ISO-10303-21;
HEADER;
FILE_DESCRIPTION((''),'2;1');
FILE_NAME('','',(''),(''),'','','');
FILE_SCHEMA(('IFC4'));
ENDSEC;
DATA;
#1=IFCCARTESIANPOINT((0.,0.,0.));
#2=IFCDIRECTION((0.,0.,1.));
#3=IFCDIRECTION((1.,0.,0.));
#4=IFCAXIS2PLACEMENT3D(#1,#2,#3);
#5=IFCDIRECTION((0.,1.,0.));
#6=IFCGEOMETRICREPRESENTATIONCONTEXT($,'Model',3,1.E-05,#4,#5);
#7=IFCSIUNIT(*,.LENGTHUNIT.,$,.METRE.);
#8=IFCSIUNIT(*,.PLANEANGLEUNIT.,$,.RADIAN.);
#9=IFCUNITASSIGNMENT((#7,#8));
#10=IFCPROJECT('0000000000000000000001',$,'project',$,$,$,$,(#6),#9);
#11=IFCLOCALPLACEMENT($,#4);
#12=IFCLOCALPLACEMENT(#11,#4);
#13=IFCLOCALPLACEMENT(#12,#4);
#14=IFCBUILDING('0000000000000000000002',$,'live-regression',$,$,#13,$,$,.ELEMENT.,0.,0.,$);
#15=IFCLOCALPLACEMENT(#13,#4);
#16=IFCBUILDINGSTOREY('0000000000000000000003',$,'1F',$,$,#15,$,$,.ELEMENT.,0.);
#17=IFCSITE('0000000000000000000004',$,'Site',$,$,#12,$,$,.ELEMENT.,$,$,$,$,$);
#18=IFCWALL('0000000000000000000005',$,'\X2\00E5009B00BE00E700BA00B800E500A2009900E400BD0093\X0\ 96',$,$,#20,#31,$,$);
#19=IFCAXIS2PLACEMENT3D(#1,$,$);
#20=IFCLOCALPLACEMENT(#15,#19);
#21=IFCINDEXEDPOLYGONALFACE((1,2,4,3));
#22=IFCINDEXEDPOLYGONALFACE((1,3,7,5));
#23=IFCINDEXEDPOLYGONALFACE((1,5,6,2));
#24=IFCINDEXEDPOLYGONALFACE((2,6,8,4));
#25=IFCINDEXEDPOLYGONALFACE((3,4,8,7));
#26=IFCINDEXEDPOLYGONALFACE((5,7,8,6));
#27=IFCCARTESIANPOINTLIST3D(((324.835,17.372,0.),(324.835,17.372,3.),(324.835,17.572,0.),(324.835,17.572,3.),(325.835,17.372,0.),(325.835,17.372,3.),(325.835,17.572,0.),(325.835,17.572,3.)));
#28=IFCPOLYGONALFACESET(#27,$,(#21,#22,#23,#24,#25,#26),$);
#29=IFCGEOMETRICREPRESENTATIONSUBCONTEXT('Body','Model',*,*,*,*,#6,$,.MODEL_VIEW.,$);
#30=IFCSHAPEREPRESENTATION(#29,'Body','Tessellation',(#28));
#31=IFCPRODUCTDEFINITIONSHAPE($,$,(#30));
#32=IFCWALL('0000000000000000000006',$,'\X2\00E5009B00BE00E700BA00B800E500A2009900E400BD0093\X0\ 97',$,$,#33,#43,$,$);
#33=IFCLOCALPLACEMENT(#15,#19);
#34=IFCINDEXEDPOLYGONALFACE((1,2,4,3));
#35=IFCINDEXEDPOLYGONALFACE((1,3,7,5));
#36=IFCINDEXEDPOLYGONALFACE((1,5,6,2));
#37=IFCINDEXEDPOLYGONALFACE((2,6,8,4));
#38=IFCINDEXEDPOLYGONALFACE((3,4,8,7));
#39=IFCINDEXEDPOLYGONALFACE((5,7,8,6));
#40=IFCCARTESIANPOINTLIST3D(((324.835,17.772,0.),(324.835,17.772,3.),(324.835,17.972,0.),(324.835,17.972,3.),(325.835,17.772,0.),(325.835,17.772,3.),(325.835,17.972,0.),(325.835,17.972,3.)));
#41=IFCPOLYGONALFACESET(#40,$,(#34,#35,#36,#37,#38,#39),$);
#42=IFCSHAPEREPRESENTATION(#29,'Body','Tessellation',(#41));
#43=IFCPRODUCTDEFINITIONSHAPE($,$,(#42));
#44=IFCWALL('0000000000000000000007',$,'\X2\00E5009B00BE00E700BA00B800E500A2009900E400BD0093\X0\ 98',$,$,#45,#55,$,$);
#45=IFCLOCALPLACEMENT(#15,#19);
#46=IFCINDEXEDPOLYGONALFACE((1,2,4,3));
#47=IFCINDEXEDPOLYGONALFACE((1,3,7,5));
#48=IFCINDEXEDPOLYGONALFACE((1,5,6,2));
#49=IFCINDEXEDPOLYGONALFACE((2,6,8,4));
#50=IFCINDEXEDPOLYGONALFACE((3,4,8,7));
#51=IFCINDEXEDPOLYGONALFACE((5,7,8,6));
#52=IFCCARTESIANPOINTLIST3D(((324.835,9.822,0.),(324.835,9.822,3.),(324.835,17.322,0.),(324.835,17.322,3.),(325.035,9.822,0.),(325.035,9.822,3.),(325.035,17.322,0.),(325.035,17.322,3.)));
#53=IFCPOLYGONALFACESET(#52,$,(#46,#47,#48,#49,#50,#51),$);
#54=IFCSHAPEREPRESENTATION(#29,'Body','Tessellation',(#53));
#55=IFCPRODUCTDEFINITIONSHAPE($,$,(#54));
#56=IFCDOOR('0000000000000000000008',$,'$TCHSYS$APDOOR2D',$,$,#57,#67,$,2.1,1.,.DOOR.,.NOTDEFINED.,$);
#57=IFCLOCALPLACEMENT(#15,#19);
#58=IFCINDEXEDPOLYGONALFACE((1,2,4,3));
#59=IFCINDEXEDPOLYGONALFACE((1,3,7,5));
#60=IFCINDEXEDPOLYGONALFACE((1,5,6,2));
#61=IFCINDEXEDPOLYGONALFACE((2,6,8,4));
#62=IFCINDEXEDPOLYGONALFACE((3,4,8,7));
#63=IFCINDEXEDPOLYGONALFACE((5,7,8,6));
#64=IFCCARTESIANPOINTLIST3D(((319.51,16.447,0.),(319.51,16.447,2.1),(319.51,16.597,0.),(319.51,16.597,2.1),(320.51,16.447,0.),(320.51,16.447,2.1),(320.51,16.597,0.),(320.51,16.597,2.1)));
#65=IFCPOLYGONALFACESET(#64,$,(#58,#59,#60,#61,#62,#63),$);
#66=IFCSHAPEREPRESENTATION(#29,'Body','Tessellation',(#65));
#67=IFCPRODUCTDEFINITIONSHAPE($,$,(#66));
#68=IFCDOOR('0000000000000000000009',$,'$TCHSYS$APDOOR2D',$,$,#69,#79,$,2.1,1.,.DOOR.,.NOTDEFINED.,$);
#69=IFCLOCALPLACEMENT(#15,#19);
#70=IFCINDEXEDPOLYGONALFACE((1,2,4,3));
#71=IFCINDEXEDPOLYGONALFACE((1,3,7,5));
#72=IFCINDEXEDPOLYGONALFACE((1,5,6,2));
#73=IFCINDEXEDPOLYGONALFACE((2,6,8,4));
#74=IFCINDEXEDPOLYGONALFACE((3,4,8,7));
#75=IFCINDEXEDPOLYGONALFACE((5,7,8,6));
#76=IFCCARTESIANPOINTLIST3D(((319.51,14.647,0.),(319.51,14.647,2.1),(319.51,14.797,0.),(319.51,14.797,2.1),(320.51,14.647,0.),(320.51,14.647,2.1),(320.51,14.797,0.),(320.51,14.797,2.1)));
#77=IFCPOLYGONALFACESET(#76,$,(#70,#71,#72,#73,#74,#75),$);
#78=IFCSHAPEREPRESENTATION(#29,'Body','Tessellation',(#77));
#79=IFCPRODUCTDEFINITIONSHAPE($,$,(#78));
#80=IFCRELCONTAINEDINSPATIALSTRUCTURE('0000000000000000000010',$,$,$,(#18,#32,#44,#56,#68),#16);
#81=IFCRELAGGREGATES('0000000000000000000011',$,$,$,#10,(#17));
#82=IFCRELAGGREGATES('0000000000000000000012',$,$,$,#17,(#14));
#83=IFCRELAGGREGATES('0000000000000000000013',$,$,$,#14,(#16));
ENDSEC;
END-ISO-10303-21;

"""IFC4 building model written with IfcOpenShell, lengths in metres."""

from ifc_helpers import new_model, si_unit, direction, frame, frame_2d, origin_with_axes, place, context, subcontext, project, spatial, rectangle, extrude, element, save


model = new_model("IFC4")

# Units and contexts
model_context = context("Model", 3, precision=1e-05, world=origin_with_axes(), true_north=direction((0.0, 1.0, 0.0)))
body_context = subcontext(model_context, "Body", "Model", "MODEL_VIEW")
ifc_project = project(units=[si_unit("LENGTHUNIT", "METRE"), si_unit("PLANEANGLEUNIT", "RADIAN")], contexts=[model_context])

# Site, building, storey
placement = place(None, origin_with_axes())
site_placement = place(placement, origin_with_axes())
site = spatial("IfcSite", under=ifc_project, at=site_placement, Name="Site", CompositionType="ELEMENT")
building_placement = place(site_placement, origin_with_axes())
building = spatial("IfcBuilding", under=site, at=building_placement, Name="live-regression", CompositionType="ELEMENT", ElevationOfRefHeight=0.0, ElevationOfTerrain=0.0)
storey_placement = place(building_placement, origin_with_axes())
storey = spatial("IfcBuildingStorey", under=building, at=storey_placement, Name="1F", CompositionType="ELEMENT", Elevation=0.0)

# Walls
for number, where, z_axis, x_axis, name in (
    (1, (325.335, 17.472, 0.0), (0.0, 0.0, 1.0), (1.0, 0.0, 0.0), "å\u009b¾çº¸å¢\u0099ä½\u0093 96"),
    (2, (325.335, 17.872, 0.0), (0.0, 0.0, 1.0), (1.0, 0.0, 0.0), "å\u009b¾çº¸å¢\u0099ä½\u0093 97"),
):
    element("IfcWall", number, at=place(storey_placement, frame(where, z_axis=z_axis, x_axis=x_axis)), inside=storey, Name=name, context=body_context, shape_type="SweptSolid", body=[
        extrude(rectangle(XDim=1.0, YDim=0.2, at=frame_2d((0.0, 0.0), x_axis=(1.0, 0.0, 0.0))), frame((0.0, 0.0, 0.0), z_axis=(0.0, 0.0, 1.0)), (0.0, 0.0, 1.0), 3.0),
    ])
wall_1_placement = place(storey_placement, frame((324.935, 13.572, 0.0), z_axis=(0.0, 0.0, 1.0), x_axis=(0.0, 1.0, 0.0)))
element("IfcWall", 3, at=wall_1_placement, inside=storey, Name="å\u009b¾çº¸å¢\u0099ä½\u0093 98", context=body_context, shape_type="SweptSolid", body=[
    extrude(rectangle(XDim=7.5, YDim=0.2, at=frame_2d((0.0, 0.0), x_axis=(1.0, 0.0, 0.0))), frame((0.0, 0.0, 0.0), z_axis=(0.0, 0.0, 1.0)), (0.0, 0.0, 1.0), 3.0),
])

# Doors
for number, where, z_axis, x_axis, name in (
    (4, (320.01, 16.522, 0.0), (0.0, 0.0, 1.0), (1.0, 0.0, 0.0), "$TCHSYS$APDOOR2D"),
    (5, (320.01, 14.722, 0.0), (0.0, 0.0, 1.0), (1.0, 0.0, 0.0), "$TCHSYS$APDOOR2D"),
):
    element("IfcDoor", number, at=place(storey_placement, frame(where, z_axis=z_axis, x_axis=x_axis)), inside=storey, Name=name, OperationType="NOTDEFINED", OverallHeight=2.1, OverallWidth=1.0, PredefinedType="DOOR", context=body_context, shape_type="SweptSolid", body=[
        extrude(rectangle(XDim=1.0, YDim=0.15, at=frame_2d((0.0, 0.0), x_axis=(1.0, 0.0, 0.0))), frame((0.0, 0.0, 0.0), z_axis=(0.0, 0.0, 1.0)), (0.0, 0.0, 1.0), 2.1),
    ])

save(model, "model.ifc")
